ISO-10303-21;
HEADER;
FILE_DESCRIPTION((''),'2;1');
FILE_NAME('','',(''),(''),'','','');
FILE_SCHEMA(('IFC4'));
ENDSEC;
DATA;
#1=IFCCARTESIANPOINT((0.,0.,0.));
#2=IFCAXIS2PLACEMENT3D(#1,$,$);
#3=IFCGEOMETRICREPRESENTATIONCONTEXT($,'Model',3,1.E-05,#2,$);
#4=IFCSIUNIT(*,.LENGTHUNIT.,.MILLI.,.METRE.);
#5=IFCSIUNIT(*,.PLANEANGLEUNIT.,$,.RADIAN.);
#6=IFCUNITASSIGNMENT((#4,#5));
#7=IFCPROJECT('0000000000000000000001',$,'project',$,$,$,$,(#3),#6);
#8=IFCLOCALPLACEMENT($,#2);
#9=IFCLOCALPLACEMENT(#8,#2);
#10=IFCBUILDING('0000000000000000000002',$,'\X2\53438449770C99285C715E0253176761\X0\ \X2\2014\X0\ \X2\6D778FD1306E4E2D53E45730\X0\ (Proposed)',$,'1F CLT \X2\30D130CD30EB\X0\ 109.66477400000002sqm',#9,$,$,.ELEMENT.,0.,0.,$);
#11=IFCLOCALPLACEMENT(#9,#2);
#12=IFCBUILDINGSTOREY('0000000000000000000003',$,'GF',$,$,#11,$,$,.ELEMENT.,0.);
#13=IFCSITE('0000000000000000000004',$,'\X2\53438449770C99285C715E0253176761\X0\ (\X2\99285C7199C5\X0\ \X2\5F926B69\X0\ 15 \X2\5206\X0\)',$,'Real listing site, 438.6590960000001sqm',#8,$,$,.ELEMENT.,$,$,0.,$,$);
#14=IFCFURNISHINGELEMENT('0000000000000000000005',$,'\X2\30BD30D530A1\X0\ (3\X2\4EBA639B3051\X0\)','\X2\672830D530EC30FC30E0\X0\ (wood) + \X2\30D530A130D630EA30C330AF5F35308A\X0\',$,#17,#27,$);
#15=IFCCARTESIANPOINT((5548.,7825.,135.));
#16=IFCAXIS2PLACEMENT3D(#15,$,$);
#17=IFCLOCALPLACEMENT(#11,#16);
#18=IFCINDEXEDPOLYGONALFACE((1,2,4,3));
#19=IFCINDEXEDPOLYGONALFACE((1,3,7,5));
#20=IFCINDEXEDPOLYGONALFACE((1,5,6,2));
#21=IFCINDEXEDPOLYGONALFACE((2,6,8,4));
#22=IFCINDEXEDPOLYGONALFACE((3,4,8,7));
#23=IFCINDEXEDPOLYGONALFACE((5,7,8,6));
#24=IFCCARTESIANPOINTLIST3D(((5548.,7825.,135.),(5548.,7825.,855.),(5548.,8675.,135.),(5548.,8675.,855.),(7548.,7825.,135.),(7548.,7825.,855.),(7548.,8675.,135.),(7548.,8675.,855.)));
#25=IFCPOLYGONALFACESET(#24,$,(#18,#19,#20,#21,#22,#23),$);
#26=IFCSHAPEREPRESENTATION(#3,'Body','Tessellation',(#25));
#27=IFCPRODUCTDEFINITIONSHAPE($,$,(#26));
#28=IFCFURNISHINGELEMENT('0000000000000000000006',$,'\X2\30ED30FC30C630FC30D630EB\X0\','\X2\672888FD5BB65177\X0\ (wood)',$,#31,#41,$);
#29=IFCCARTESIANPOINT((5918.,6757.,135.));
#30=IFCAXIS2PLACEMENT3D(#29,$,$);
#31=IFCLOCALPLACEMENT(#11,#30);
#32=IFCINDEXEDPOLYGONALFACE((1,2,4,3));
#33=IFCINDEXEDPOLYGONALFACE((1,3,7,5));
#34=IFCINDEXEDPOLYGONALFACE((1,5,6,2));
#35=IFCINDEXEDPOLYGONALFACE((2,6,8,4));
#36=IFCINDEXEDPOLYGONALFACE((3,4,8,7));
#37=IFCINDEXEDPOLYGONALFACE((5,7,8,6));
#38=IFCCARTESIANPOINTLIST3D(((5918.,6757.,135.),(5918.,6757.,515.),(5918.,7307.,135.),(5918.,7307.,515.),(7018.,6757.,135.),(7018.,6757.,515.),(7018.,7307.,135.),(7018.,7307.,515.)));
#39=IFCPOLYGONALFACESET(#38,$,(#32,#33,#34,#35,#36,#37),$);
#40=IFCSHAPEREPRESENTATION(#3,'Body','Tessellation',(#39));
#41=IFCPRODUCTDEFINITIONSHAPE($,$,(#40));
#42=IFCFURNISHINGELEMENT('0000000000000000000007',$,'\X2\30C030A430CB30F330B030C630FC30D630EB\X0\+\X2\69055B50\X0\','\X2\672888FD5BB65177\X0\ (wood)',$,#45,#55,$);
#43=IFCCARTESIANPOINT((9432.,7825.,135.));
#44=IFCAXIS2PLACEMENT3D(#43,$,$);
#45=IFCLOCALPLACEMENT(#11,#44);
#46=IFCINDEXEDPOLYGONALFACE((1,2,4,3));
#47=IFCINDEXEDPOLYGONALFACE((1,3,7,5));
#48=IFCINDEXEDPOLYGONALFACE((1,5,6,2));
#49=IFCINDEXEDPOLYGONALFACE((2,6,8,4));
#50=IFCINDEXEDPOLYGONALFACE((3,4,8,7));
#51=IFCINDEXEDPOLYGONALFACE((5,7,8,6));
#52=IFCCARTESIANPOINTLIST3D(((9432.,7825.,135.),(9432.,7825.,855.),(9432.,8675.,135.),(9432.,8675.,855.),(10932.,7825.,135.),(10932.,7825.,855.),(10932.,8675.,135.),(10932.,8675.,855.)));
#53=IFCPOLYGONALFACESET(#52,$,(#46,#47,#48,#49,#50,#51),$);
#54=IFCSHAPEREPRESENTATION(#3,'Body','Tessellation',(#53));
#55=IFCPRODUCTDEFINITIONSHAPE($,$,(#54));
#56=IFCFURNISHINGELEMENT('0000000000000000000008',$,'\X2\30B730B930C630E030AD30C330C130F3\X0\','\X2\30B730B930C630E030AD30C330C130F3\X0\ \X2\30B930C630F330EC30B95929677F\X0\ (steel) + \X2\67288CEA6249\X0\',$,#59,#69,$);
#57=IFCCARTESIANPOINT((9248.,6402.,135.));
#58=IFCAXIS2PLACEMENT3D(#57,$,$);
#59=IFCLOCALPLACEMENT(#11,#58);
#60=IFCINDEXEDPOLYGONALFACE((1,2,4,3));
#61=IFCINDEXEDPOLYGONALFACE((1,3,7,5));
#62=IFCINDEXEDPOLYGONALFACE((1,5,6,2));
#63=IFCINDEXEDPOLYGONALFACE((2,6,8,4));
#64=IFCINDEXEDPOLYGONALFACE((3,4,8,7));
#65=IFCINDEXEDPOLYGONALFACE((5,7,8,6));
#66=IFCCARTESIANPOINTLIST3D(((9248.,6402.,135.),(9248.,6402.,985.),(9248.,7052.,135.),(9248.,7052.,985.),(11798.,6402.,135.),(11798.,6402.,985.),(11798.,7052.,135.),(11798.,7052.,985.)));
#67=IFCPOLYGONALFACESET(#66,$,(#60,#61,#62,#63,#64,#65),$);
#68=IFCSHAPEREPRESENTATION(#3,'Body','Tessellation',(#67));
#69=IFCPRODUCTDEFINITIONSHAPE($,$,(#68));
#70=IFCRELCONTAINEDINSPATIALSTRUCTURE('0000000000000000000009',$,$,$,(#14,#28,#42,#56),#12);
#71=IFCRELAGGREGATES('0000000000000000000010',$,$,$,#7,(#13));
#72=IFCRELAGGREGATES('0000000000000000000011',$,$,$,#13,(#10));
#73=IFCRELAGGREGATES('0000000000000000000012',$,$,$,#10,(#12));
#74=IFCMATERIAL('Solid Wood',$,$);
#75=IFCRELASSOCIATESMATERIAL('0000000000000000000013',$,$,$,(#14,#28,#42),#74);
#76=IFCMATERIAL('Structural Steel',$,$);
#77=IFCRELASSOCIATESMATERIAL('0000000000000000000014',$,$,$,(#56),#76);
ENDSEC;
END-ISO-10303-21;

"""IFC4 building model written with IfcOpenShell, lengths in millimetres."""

from ifc_helpers import new_model, si_unit, frame, frame_2d, origin, place, context, project, spatial, rectangle, extrude, material, element, save


model = new_model("IFC4")

# Units and contexts
model_context = context("Model", 3, precision=1e-05, world=origin())
ifc_project = project(units=[si_unit("LENGTHUNIT", "METRE", prefix="MILLI"), si_unit("PLANEANGLEUNIT", "RADIAN")], contexts=[model_context])

# Site, building, storey
site_placement = place(None, origin())
site = spatial("IfcSite", under=ifc_project, at=site_placement, Name="千葉県館山市北条 (館山駅 徒歩 15 分)", ObjectType="Real listing site, 438.6590960000001sqm", CompositionType="ELEMENT", RefElevation=0.0)
building_placement = place(site_placement, origin())
building = spatial("IfcBuilding", under=site, at=building_placement, Name="千葉県館山市北条 — 海近の中古地 (Proposed)", ObjectType="1F CLT パネル 109.66477400000002sqm", CompositionType="ELEMENT", ElevationOfRefHeight=0.0, ElevationOfTerrain=0.0)
storey_placement = place(building_placement, origin())
storey = spatial("IfcBuildingStorey", under=building, at=storey_placement, Name="GF", CompositionType="ELEMENT", Elevation=0.0)

# Shared definitions
ifc_material_1 = material(Name="Solid Wood")

# Shared definitions
ifc_material_2 = material(Name="Structural Steel")

# Furnishing elements
furnishing_1_placement = place(storey_placement, frame((5548.0, 7825.0, 135.0)))
element("IfcFurnishingElement", 1, at=furnishing_1_placement, inside=storey, material=ifc_material_1, Name="ソファ (3人掛け)", Description="木フレーム (wood) + ファブリック張り", context=model_context, shape_type="SweptSolid", body=[
    extrude(rectangle(XDim=2000.0, YDim=850.0, at=frame_2d((1000.0, 425.0))), frame((5548.0, 7825.0, 135.0)), (0.0, 0.0, 1.0), 720.0),
])
furnishing_2_placement = place(storey_placement, frame((5918.0, 6757.0, 135.0)))
element("IfcFurnishingElement", 2, at=furnishing_2_placement, inside=storey, material=ifc_material_1, Name="ローテーブル", Description="木製家具 (wood)", context=model_context, shape_type="SweptSolid", body=[
    extrude(rectangle(XDim=1100.0, YDim=550.0, at=frame_2d((550.0, 275.0))), frame((5918.0, 6757.0, 135.0)), (0.0, 0.0, 1.0), 380.0),
])
furnishing_3_placement = place(storey_placement, frame((9432.0, 7825.0, 135.0)))
element("IfcFurnishingElement", 3, at=furnishing_3_placement, inside=storey, material=ifc_material_1, Name="ダイニングテーブル+椅子", Description="木製家具 (wood)", context=model_context, shape_type="SweptSolid", body=[
    extrude(rectangle(XDim=1500.0, YDim=850.0, at=frame_2d((750.0, 425.0))), frame((9432.0, 7825.0, 135.0)), (0.0, 0.0, 1.0), 720.0),
])
furnishing_4_placement = place(storey_placement, frame((9248.0, 6402.0, 135.0)))
element("IfcFurnishingElement", 4, at=furnishing_4_placement, inside=storey, material=ifc_material_2, Name="システムキッチン", Description="システムキッチン ステンレス天板 (steel) + 木質扉", context=model_context, shape_type="SweptSolid", body=[
    extrude(rectangle(XDim=2550.0, YDim=650.0, at=frame_2d((1275.0, 325.0))), frame((9248.0, 6402.0, 135.0)), (0.0, 0.0, 1.0), 850.0),
])

save(model, "model.ifc")
